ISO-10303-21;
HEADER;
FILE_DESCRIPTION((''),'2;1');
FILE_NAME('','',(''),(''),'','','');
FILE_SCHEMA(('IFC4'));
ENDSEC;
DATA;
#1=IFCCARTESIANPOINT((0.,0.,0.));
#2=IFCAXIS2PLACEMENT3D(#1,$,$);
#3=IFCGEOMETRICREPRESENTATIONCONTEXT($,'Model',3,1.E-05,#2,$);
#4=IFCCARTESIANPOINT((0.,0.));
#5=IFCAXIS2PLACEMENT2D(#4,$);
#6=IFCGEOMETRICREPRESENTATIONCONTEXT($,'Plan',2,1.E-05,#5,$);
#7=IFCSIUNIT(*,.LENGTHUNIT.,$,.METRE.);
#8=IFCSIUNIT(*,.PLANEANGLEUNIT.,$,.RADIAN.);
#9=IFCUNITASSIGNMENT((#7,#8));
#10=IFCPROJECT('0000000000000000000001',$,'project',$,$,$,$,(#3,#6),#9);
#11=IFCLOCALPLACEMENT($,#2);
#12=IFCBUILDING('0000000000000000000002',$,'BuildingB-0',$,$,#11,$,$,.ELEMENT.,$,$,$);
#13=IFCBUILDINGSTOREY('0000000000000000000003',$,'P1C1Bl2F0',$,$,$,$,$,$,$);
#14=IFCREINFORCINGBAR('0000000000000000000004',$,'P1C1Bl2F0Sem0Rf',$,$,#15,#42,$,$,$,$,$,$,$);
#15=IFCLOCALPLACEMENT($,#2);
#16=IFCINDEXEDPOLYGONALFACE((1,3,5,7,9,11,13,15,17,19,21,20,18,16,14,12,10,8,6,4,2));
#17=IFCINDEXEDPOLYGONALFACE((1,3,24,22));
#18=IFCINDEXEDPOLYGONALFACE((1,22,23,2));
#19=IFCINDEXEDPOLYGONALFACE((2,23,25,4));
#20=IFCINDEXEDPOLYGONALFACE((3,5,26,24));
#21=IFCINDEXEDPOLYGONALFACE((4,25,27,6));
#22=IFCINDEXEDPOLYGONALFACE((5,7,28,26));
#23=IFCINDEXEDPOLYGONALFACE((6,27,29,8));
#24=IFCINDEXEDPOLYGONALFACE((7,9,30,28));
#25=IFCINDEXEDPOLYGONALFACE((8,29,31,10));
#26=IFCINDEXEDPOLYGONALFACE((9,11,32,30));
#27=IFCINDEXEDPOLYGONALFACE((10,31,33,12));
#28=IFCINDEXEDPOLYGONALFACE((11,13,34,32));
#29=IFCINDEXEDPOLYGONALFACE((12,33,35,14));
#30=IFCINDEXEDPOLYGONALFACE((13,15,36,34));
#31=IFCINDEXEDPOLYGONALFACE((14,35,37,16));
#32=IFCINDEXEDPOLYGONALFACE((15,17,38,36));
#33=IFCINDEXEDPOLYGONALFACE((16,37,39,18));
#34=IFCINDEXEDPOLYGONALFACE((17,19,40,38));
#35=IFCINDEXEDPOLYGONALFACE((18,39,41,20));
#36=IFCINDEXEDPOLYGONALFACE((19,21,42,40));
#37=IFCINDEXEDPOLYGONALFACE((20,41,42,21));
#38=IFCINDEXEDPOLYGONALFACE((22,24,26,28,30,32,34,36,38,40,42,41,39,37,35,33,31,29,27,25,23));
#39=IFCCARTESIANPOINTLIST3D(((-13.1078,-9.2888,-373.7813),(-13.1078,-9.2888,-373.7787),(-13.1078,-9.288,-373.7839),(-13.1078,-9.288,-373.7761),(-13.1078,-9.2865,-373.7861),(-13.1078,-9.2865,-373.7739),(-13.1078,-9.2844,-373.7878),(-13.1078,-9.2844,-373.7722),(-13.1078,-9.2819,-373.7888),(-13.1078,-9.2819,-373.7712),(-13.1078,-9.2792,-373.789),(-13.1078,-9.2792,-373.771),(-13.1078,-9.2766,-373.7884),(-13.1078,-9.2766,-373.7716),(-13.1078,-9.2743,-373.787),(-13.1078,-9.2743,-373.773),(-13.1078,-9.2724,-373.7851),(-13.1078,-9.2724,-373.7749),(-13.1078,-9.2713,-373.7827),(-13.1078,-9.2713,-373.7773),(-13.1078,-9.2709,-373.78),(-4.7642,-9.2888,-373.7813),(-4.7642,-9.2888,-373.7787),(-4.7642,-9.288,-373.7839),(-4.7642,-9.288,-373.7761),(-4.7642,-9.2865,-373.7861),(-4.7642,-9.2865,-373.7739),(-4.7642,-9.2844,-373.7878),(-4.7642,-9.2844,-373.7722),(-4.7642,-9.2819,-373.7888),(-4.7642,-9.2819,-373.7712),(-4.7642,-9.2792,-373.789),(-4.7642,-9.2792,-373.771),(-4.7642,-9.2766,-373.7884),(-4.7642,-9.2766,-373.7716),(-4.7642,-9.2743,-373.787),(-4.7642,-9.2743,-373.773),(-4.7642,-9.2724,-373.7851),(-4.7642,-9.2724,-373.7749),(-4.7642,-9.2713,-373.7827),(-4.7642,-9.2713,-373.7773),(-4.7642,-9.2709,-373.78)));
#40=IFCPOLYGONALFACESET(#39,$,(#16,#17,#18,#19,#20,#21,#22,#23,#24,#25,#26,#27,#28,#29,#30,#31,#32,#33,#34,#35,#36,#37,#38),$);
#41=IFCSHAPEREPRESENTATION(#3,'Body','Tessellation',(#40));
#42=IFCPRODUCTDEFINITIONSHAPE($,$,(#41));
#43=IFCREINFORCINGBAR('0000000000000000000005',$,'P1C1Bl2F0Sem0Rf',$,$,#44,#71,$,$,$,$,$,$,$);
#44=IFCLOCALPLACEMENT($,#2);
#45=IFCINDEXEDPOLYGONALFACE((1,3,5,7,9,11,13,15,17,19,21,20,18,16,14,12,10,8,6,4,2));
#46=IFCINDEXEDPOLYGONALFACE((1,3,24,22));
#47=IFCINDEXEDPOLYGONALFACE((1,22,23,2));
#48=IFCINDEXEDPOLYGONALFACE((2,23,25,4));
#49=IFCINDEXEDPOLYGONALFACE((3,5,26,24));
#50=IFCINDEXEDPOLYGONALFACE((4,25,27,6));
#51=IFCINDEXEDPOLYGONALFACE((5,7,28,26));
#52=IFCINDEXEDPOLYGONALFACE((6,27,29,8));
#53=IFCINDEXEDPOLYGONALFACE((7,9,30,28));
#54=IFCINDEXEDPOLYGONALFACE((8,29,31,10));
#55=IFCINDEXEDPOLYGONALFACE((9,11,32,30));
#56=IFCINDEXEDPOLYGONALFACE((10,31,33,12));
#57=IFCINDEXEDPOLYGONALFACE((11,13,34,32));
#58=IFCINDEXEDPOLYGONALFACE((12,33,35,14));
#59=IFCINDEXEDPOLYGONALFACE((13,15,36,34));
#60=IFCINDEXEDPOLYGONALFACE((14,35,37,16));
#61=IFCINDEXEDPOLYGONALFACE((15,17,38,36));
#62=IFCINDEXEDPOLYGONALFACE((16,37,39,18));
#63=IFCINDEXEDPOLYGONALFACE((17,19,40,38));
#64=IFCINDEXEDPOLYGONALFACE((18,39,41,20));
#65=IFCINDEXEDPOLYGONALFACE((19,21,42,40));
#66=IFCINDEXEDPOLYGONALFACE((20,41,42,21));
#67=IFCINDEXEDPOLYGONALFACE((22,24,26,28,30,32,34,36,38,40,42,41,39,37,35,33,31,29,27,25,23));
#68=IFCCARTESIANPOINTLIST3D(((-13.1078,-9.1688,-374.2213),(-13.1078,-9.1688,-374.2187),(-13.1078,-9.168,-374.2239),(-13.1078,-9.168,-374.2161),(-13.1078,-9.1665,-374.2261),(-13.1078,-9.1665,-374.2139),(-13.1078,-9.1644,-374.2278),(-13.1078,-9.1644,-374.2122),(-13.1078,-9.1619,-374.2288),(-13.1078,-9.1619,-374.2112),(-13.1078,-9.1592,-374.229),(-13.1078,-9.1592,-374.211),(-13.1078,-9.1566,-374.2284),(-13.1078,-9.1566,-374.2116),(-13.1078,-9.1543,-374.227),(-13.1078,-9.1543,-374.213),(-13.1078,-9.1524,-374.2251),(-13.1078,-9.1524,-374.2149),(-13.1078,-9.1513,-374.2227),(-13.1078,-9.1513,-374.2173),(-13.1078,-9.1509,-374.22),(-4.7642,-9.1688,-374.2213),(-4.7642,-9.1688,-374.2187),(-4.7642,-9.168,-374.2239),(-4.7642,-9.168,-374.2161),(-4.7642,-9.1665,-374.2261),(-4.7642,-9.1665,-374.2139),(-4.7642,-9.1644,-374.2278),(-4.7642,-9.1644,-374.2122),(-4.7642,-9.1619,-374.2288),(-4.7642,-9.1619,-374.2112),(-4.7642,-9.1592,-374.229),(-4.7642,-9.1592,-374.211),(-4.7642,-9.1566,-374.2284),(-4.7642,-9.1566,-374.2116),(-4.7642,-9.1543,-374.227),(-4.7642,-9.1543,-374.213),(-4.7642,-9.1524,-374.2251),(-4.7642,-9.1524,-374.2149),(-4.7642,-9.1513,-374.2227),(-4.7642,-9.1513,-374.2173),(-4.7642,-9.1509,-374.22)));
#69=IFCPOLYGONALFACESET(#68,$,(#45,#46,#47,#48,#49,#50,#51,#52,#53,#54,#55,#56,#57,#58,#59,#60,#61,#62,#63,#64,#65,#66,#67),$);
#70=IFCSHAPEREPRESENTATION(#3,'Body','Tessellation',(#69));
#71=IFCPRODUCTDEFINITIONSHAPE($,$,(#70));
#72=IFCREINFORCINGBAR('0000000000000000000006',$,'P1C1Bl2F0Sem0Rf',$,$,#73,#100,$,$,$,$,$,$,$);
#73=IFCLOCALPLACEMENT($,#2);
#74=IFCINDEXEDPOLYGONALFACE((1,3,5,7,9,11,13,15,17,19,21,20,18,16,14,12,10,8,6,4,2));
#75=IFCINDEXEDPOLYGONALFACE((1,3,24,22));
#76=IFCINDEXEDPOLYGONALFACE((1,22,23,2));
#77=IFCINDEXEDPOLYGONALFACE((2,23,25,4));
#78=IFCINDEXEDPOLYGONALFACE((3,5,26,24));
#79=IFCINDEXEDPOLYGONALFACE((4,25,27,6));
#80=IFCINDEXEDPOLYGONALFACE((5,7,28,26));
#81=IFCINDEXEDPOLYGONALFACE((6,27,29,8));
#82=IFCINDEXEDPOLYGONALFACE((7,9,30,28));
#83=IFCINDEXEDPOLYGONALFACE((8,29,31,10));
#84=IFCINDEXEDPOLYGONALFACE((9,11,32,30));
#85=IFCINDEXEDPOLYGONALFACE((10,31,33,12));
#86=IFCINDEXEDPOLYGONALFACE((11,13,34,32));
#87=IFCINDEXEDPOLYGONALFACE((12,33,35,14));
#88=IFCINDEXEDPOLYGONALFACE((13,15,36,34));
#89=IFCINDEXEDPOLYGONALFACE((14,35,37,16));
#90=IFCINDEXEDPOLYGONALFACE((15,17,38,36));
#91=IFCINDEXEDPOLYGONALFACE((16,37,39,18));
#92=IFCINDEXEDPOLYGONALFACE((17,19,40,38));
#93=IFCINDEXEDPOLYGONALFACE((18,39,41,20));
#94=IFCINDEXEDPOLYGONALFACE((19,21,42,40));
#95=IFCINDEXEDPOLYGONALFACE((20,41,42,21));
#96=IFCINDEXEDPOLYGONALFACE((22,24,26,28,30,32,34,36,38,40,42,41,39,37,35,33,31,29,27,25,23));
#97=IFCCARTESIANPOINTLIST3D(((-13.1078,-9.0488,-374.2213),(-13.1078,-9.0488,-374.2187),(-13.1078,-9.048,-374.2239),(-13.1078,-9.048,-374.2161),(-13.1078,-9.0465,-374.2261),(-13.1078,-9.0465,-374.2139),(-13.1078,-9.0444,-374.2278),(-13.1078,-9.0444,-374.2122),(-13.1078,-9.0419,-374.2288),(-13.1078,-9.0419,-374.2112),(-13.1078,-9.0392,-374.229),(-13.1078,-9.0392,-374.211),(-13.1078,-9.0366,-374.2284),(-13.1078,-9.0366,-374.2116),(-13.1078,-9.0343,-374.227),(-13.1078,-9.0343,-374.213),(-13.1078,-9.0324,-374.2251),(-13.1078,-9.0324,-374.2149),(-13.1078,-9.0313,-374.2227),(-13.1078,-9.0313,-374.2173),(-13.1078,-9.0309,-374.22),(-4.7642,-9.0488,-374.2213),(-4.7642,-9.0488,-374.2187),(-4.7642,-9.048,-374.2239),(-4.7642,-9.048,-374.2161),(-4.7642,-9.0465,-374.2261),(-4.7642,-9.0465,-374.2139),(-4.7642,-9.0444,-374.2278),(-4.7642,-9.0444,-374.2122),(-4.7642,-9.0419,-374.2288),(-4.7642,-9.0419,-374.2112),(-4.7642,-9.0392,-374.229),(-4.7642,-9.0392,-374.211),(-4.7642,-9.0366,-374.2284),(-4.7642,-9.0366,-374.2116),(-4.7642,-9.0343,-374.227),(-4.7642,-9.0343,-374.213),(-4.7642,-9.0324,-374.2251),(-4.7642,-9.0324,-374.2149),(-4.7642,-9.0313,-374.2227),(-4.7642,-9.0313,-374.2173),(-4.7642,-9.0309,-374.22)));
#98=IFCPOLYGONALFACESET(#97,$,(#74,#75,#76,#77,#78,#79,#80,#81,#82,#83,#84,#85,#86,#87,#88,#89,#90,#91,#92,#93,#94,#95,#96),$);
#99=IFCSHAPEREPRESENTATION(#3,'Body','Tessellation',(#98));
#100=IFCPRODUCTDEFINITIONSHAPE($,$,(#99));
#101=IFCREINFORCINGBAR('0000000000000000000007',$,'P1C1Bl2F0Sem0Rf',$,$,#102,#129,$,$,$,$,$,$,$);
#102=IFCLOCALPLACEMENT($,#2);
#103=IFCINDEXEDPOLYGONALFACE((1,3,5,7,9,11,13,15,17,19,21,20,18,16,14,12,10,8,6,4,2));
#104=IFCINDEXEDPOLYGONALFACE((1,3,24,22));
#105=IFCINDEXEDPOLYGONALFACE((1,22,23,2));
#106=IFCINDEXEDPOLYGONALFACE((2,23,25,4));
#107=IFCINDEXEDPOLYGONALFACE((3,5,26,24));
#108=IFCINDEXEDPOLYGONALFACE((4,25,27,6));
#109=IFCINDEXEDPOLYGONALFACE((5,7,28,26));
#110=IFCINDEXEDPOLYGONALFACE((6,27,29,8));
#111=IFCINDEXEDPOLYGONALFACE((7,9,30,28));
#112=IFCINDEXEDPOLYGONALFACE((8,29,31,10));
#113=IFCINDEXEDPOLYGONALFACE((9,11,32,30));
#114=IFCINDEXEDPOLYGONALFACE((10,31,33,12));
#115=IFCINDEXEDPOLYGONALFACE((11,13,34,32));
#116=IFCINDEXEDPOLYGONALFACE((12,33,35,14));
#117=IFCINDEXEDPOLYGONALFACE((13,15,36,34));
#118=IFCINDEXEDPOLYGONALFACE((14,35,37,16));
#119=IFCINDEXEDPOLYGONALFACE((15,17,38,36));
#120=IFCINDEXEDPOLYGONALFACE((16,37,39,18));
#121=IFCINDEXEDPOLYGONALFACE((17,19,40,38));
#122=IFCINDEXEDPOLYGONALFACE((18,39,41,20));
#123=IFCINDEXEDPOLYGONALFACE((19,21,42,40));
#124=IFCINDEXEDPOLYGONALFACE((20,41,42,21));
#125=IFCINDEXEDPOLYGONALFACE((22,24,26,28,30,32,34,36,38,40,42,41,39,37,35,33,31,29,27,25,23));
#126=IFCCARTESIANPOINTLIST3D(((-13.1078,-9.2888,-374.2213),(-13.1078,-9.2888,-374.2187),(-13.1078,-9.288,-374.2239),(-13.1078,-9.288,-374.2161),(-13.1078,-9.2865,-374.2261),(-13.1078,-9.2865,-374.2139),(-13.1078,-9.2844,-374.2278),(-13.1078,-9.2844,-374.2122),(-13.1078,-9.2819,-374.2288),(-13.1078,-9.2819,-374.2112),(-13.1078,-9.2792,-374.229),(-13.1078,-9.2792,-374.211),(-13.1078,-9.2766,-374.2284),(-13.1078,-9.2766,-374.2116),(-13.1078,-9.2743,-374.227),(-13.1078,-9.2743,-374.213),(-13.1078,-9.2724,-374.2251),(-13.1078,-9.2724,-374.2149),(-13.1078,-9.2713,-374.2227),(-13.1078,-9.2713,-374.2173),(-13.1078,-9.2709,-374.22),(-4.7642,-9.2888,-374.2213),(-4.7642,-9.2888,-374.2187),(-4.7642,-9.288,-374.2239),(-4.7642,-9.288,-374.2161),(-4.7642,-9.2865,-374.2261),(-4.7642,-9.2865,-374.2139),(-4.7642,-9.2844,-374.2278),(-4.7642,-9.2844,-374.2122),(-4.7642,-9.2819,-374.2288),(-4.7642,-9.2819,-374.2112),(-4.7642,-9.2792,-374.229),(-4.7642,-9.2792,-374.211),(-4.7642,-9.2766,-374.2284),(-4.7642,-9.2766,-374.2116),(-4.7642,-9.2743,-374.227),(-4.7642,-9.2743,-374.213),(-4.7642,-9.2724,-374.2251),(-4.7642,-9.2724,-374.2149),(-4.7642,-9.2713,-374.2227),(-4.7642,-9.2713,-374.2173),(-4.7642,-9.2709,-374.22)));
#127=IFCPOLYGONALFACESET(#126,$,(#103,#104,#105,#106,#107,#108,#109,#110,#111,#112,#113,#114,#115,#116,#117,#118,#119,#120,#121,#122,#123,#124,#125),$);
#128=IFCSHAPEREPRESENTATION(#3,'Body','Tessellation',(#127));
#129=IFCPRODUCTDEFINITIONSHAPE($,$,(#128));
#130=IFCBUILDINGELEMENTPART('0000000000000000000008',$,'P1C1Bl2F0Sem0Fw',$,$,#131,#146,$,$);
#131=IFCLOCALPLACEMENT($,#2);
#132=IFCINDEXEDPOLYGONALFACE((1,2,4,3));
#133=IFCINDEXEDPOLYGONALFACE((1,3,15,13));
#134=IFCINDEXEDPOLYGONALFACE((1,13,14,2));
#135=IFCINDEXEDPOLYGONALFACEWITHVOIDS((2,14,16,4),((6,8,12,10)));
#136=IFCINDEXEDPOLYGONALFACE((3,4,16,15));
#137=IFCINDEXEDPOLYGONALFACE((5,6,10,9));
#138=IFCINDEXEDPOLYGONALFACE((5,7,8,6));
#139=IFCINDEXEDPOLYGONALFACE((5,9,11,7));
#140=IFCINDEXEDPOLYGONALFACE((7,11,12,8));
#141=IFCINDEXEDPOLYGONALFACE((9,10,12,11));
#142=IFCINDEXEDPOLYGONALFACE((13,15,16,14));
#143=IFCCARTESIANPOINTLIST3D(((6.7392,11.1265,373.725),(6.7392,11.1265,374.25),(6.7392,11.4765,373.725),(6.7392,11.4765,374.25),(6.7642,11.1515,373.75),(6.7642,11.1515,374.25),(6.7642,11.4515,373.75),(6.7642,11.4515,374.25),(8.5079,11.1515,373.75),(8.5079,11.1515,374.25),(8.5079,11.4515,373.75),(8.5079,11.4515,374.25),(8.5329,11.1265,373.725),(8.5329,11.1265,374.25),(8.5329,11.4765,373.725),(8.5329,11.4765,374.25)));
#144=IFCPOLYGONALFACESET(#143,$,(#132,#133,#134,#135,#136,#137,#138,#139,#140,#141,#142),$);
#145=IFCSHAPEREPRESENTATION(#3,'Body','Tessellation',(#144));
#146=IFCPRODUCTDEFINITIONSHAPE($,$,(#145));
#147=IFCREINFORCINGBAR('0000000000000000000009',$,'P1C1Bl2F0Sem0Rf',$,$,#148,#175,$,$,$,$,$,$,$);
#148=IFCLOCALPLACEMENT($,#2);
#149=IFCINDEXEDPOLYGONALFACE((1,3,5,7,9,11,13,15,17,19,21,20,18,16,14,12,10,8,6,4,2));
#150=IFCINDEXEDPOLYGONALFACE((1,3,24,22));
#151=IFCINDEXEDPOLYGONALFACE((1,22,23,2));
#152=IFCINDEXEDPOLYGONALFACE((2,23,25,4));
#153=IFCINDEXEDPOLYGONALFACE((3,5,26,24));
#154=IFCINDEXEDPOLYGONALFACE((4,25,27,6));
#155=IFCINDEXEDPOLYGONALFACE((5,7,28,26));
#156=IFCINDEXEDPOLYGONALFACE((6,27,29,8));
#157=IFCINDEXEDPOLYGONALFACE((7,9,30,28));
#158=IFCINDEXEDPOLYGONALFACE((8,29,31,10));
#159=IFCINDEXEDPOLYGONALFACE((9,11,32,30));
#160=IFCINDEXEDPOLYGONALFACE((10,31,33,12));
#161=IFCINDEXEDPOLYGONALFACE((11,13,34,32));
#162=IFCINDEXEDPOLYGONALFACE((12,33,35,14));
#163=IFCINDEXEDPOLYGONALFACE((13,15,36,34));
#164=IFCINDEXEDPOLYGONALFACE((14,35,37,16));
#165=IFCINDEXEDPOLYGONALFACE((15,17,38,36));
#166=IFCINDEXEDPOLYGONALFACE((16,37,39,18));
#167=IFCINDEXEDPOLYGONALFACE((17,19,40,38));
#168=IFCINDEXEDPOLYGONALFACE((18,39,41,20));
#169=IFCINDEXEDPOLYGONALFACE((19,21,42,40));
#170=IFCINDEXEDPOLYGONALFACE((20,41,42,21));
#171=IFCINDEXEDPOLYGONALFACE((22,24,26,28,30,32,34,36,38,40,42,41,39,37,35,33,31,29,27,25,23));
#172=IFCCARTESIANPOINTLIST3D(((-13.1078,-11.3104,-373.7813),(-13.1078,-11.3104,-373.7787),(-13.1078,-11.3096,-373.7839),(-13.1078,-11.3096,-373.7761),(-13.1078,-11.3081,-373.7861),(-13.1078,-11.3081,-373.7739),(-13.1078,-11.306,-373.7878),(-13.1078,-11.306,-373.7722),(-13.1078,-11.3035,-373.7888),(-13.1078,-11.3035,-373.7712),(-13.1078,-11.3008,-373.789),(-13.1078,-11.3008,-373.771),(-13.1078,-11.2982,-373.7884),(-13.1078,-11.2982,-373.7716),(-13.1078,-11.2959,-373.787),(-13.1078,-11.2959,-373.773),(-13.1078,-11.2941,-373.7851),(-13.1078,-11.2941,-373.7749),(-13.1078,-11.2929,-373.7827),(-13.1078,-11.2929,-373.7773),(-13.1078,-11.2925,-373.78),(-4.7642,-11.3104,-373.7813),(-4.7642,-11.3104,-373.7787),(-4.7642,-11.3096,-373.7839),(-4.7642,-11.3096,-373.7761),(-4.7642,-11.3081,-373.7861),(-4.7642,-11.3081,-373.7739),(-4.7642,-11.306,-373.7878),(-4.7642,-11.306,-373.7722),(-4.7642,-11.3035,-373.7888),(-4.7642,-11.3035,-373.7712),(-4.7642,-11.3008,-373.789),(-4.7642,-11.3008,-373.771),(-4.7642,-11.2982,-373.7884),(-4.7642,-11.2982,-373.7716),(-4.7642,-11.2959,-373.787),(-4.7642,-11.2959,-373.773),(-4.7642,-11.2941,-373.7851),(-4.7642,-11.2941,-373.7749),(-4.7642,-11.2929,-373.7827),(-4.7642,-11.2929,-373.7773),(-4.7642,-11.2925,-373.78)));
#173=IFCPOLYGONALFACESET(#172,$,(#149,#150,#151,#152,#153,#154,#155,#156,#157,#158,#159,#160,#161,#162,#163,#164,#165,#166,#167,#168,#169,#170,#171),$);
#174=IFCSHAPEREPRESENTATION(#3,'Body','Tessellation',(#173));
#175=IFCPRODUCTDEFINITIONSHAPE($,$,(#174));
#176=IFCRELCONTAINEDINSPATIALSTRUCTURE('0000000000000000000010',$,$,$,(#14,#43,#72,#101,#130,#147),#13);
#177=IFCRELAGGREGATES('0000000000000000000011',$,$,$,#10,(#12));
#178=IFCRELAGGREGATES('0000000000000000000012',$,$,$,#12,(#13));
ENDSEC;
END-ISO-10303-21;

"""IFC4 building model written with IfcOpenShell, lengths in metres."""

from ifc_helpers import new_model, entity, si_unit, origin, origin_2d, place, context, project, spatial, polyline, outline, extrude, element, save


model = new_model("IFC4")

# Units and contexts
model_context = context("Model", 3, precision=1e-05, world=origin())
plan_context = context("Plan", 2, precision=1e-05, world=origin_2d())
ifc_project = project(units=[si_unit("LENGTHUNIT", "METRE"), si_unit("PLANEANGLEUNIT", "RADIAN")], contexts=[model_context, plan_context])

# Building, storey
building_placement = place(None, origin())
building = spatial("IfcBuilding", under=ifc_project, at=building_placement, Name="BuildingB-0", CompositionType="ELEMENT")
storey = spatial("IfcBuildingStorey", under=building, Name="P1C1Bl2F0")

# Reinforcing bars
element("IfcReinforcingBar", 1, inside=storey, Name="P1C1Bl2F0Sem0Rf", context=model_context, shape_type="SweptSolid", body=[
    entity("IfcSurfaceCurveSweptAreaSolid", entity("IfcCircleProfileDef", "AREA", None, None, 0.009), None, entity("IfcPolyline", [entity("IfcCartesianPoint", [4.7642, 9.2799, 373.78]), entity("IfcCartesianPoint", [13.1078, 9.2799, 373.78])]), None, None, entity("IfcPlane", entity("IfcAxis2Placement3D", entity("IfcCartesianPoint", [4.7642, 9.2799, 373.78]), entity("IfcDirection", [0.0, 0.0, 1.0]), entity("IfcDirection", [1.0, 0.0, 0.0])))),
])
element("IfcReinforcingBar", 2, inside=storey, Name="P1C1Bl2F0Sem0Rf", context=model_context, shape_type="SweptSolid", body=[
    entity("IfcSurfaceCurveSweptAreaSolid", entity("IfcCircleProfileDef", "AREA", None, None, 0.009), None, entity("IfcPolyline", [entity("IfcCartesianPoint", [4.7642, 9.1599, 374.22]), entity("IfcCartesianPoint", [13.1078, 9.1599, 374.22])]), None, None, entity("IfcPlane", entity("IfcAxis2Placement3D", entity("IfcCartesianPoint", [4.7642, 9.1599, 374.22]), entity("IfcDirection", [0.0, 0.0, 1.0]), entity("IfcDirection", [1.0, 0.0, 0.0])))),
])
element("IfcReinforcingBar", 3, inside=storey, Name="P1C1Bl2F0Sem0Rf", context=model_context, shape_type="SweptSolid", body=[
    entity("IfcSurfaceCurveSweptAreaSolid", entity("IfcCircleProfileDef", "AREA", None, None, 0.009), None, entity("IfcPolyline", [entity("IfcCartesianPoint", [4.7642, 9.0399, 374.22]), entity("IfcCartesianPoint", [13.1078, 9.0399, 374.22])]), None, None, entity("IfcPlane", entity("IfcAxis2Placement3D", entity("IfcCartesianPoint", [4.7642, 9.0399, 374.22]), entity("IfcDirection", [0.0, 0.0, 1.0]), entity("IfcDirection", [1.0, 0.0, 0.0])))),
])
element("IfcReinforcingBar", 4, inside=storey, Name="P1C1Bl2F0Sem0Rf", context=model_context, shape_type="SweptSolid", body=[
    entity("IfcSurfaceCurveSweptAreaSolid", entity("IfcCircleProfileDef", "AREA", None, None, 0.009), None, entity("IfcPolyline", [entity("IfcCartesianPoint", [4.7642, 9.2799, 374.22]), entity("IfcCartesianPoint", [13.1078, 9.2799, 374.22])]), None, None, entity("IfcPlane", entity("IfcAxis2Placement3D", entity("IfcCartesianPoint", [4.7642, 9.2799, 374.22]), entity("IfcDirection", [0.0, 0.0, 1.0]), entity("IfcDirection", [1.0, 0.0, 0.0])))),
])

# Building element part, opening
building_element_part_1 = element("IfcBuildingElementPart", 5, inside=storey, Name="P1C1Bl2F0Sem0Fw", context=model_context, shape_type="SweptSolid", body=[
    extrude(outline(polyline([(6.7392, 11.1265, 373.725), (6.7392, 11.4765, 373.725), (8.5329, 11.4765, 373.725), (8.5329, 11.1265, 373.725), (6.7392, 11.1265, 373.725)])), None, (0.0, 0.0, 1.0), 0.525),
])
element("IfcOpeningElement", 6, inside=storey, cuts=building_element_part_1, context=model_context, shape_type="SweptSolid", body=[
    extrude(outline(polyline([(6.7642, 11.1515, 373.75), (6.7642, 11.4515, 373.75), (8.5079, 11.4515, 373.75), (8.5079, 11.1515, 373.75), (6.7642, 11.1515, 373.75)])), None, (0.0, 0.0, 1.0), 0.5),
])

# Reinforcing bar
element("IfcReinforcingBar", 7, inside=storey, Name="P1C1Bl2F0Sem0Rf", context=model_context, shape_type="SweptSolid", body=[
    entity("IfcSurfaceCurveSweptAreaSolid", entity("IfcCircleProfileDef", "AREA", None, None, 0.009), None, entity("IfcPolyline", [entity("IfcCartesianPoint", [4.7642, 11.3015, 373.78]), entity("IfcCartesianPoint", [13.1078, 11.3015, 373.78])]), None, None, entity("IfcPlane", entity("IfcAxis2Placement3D", entity("IfcCartesianPoint", [4.7642, 11.3015, 373.78]), entity("IfcDirection", [0.0, 0.0, 1.0]), entity("IfcDirection", [1.0, 0.0, 0.0])))),
])

save(model, "model.ifc")
